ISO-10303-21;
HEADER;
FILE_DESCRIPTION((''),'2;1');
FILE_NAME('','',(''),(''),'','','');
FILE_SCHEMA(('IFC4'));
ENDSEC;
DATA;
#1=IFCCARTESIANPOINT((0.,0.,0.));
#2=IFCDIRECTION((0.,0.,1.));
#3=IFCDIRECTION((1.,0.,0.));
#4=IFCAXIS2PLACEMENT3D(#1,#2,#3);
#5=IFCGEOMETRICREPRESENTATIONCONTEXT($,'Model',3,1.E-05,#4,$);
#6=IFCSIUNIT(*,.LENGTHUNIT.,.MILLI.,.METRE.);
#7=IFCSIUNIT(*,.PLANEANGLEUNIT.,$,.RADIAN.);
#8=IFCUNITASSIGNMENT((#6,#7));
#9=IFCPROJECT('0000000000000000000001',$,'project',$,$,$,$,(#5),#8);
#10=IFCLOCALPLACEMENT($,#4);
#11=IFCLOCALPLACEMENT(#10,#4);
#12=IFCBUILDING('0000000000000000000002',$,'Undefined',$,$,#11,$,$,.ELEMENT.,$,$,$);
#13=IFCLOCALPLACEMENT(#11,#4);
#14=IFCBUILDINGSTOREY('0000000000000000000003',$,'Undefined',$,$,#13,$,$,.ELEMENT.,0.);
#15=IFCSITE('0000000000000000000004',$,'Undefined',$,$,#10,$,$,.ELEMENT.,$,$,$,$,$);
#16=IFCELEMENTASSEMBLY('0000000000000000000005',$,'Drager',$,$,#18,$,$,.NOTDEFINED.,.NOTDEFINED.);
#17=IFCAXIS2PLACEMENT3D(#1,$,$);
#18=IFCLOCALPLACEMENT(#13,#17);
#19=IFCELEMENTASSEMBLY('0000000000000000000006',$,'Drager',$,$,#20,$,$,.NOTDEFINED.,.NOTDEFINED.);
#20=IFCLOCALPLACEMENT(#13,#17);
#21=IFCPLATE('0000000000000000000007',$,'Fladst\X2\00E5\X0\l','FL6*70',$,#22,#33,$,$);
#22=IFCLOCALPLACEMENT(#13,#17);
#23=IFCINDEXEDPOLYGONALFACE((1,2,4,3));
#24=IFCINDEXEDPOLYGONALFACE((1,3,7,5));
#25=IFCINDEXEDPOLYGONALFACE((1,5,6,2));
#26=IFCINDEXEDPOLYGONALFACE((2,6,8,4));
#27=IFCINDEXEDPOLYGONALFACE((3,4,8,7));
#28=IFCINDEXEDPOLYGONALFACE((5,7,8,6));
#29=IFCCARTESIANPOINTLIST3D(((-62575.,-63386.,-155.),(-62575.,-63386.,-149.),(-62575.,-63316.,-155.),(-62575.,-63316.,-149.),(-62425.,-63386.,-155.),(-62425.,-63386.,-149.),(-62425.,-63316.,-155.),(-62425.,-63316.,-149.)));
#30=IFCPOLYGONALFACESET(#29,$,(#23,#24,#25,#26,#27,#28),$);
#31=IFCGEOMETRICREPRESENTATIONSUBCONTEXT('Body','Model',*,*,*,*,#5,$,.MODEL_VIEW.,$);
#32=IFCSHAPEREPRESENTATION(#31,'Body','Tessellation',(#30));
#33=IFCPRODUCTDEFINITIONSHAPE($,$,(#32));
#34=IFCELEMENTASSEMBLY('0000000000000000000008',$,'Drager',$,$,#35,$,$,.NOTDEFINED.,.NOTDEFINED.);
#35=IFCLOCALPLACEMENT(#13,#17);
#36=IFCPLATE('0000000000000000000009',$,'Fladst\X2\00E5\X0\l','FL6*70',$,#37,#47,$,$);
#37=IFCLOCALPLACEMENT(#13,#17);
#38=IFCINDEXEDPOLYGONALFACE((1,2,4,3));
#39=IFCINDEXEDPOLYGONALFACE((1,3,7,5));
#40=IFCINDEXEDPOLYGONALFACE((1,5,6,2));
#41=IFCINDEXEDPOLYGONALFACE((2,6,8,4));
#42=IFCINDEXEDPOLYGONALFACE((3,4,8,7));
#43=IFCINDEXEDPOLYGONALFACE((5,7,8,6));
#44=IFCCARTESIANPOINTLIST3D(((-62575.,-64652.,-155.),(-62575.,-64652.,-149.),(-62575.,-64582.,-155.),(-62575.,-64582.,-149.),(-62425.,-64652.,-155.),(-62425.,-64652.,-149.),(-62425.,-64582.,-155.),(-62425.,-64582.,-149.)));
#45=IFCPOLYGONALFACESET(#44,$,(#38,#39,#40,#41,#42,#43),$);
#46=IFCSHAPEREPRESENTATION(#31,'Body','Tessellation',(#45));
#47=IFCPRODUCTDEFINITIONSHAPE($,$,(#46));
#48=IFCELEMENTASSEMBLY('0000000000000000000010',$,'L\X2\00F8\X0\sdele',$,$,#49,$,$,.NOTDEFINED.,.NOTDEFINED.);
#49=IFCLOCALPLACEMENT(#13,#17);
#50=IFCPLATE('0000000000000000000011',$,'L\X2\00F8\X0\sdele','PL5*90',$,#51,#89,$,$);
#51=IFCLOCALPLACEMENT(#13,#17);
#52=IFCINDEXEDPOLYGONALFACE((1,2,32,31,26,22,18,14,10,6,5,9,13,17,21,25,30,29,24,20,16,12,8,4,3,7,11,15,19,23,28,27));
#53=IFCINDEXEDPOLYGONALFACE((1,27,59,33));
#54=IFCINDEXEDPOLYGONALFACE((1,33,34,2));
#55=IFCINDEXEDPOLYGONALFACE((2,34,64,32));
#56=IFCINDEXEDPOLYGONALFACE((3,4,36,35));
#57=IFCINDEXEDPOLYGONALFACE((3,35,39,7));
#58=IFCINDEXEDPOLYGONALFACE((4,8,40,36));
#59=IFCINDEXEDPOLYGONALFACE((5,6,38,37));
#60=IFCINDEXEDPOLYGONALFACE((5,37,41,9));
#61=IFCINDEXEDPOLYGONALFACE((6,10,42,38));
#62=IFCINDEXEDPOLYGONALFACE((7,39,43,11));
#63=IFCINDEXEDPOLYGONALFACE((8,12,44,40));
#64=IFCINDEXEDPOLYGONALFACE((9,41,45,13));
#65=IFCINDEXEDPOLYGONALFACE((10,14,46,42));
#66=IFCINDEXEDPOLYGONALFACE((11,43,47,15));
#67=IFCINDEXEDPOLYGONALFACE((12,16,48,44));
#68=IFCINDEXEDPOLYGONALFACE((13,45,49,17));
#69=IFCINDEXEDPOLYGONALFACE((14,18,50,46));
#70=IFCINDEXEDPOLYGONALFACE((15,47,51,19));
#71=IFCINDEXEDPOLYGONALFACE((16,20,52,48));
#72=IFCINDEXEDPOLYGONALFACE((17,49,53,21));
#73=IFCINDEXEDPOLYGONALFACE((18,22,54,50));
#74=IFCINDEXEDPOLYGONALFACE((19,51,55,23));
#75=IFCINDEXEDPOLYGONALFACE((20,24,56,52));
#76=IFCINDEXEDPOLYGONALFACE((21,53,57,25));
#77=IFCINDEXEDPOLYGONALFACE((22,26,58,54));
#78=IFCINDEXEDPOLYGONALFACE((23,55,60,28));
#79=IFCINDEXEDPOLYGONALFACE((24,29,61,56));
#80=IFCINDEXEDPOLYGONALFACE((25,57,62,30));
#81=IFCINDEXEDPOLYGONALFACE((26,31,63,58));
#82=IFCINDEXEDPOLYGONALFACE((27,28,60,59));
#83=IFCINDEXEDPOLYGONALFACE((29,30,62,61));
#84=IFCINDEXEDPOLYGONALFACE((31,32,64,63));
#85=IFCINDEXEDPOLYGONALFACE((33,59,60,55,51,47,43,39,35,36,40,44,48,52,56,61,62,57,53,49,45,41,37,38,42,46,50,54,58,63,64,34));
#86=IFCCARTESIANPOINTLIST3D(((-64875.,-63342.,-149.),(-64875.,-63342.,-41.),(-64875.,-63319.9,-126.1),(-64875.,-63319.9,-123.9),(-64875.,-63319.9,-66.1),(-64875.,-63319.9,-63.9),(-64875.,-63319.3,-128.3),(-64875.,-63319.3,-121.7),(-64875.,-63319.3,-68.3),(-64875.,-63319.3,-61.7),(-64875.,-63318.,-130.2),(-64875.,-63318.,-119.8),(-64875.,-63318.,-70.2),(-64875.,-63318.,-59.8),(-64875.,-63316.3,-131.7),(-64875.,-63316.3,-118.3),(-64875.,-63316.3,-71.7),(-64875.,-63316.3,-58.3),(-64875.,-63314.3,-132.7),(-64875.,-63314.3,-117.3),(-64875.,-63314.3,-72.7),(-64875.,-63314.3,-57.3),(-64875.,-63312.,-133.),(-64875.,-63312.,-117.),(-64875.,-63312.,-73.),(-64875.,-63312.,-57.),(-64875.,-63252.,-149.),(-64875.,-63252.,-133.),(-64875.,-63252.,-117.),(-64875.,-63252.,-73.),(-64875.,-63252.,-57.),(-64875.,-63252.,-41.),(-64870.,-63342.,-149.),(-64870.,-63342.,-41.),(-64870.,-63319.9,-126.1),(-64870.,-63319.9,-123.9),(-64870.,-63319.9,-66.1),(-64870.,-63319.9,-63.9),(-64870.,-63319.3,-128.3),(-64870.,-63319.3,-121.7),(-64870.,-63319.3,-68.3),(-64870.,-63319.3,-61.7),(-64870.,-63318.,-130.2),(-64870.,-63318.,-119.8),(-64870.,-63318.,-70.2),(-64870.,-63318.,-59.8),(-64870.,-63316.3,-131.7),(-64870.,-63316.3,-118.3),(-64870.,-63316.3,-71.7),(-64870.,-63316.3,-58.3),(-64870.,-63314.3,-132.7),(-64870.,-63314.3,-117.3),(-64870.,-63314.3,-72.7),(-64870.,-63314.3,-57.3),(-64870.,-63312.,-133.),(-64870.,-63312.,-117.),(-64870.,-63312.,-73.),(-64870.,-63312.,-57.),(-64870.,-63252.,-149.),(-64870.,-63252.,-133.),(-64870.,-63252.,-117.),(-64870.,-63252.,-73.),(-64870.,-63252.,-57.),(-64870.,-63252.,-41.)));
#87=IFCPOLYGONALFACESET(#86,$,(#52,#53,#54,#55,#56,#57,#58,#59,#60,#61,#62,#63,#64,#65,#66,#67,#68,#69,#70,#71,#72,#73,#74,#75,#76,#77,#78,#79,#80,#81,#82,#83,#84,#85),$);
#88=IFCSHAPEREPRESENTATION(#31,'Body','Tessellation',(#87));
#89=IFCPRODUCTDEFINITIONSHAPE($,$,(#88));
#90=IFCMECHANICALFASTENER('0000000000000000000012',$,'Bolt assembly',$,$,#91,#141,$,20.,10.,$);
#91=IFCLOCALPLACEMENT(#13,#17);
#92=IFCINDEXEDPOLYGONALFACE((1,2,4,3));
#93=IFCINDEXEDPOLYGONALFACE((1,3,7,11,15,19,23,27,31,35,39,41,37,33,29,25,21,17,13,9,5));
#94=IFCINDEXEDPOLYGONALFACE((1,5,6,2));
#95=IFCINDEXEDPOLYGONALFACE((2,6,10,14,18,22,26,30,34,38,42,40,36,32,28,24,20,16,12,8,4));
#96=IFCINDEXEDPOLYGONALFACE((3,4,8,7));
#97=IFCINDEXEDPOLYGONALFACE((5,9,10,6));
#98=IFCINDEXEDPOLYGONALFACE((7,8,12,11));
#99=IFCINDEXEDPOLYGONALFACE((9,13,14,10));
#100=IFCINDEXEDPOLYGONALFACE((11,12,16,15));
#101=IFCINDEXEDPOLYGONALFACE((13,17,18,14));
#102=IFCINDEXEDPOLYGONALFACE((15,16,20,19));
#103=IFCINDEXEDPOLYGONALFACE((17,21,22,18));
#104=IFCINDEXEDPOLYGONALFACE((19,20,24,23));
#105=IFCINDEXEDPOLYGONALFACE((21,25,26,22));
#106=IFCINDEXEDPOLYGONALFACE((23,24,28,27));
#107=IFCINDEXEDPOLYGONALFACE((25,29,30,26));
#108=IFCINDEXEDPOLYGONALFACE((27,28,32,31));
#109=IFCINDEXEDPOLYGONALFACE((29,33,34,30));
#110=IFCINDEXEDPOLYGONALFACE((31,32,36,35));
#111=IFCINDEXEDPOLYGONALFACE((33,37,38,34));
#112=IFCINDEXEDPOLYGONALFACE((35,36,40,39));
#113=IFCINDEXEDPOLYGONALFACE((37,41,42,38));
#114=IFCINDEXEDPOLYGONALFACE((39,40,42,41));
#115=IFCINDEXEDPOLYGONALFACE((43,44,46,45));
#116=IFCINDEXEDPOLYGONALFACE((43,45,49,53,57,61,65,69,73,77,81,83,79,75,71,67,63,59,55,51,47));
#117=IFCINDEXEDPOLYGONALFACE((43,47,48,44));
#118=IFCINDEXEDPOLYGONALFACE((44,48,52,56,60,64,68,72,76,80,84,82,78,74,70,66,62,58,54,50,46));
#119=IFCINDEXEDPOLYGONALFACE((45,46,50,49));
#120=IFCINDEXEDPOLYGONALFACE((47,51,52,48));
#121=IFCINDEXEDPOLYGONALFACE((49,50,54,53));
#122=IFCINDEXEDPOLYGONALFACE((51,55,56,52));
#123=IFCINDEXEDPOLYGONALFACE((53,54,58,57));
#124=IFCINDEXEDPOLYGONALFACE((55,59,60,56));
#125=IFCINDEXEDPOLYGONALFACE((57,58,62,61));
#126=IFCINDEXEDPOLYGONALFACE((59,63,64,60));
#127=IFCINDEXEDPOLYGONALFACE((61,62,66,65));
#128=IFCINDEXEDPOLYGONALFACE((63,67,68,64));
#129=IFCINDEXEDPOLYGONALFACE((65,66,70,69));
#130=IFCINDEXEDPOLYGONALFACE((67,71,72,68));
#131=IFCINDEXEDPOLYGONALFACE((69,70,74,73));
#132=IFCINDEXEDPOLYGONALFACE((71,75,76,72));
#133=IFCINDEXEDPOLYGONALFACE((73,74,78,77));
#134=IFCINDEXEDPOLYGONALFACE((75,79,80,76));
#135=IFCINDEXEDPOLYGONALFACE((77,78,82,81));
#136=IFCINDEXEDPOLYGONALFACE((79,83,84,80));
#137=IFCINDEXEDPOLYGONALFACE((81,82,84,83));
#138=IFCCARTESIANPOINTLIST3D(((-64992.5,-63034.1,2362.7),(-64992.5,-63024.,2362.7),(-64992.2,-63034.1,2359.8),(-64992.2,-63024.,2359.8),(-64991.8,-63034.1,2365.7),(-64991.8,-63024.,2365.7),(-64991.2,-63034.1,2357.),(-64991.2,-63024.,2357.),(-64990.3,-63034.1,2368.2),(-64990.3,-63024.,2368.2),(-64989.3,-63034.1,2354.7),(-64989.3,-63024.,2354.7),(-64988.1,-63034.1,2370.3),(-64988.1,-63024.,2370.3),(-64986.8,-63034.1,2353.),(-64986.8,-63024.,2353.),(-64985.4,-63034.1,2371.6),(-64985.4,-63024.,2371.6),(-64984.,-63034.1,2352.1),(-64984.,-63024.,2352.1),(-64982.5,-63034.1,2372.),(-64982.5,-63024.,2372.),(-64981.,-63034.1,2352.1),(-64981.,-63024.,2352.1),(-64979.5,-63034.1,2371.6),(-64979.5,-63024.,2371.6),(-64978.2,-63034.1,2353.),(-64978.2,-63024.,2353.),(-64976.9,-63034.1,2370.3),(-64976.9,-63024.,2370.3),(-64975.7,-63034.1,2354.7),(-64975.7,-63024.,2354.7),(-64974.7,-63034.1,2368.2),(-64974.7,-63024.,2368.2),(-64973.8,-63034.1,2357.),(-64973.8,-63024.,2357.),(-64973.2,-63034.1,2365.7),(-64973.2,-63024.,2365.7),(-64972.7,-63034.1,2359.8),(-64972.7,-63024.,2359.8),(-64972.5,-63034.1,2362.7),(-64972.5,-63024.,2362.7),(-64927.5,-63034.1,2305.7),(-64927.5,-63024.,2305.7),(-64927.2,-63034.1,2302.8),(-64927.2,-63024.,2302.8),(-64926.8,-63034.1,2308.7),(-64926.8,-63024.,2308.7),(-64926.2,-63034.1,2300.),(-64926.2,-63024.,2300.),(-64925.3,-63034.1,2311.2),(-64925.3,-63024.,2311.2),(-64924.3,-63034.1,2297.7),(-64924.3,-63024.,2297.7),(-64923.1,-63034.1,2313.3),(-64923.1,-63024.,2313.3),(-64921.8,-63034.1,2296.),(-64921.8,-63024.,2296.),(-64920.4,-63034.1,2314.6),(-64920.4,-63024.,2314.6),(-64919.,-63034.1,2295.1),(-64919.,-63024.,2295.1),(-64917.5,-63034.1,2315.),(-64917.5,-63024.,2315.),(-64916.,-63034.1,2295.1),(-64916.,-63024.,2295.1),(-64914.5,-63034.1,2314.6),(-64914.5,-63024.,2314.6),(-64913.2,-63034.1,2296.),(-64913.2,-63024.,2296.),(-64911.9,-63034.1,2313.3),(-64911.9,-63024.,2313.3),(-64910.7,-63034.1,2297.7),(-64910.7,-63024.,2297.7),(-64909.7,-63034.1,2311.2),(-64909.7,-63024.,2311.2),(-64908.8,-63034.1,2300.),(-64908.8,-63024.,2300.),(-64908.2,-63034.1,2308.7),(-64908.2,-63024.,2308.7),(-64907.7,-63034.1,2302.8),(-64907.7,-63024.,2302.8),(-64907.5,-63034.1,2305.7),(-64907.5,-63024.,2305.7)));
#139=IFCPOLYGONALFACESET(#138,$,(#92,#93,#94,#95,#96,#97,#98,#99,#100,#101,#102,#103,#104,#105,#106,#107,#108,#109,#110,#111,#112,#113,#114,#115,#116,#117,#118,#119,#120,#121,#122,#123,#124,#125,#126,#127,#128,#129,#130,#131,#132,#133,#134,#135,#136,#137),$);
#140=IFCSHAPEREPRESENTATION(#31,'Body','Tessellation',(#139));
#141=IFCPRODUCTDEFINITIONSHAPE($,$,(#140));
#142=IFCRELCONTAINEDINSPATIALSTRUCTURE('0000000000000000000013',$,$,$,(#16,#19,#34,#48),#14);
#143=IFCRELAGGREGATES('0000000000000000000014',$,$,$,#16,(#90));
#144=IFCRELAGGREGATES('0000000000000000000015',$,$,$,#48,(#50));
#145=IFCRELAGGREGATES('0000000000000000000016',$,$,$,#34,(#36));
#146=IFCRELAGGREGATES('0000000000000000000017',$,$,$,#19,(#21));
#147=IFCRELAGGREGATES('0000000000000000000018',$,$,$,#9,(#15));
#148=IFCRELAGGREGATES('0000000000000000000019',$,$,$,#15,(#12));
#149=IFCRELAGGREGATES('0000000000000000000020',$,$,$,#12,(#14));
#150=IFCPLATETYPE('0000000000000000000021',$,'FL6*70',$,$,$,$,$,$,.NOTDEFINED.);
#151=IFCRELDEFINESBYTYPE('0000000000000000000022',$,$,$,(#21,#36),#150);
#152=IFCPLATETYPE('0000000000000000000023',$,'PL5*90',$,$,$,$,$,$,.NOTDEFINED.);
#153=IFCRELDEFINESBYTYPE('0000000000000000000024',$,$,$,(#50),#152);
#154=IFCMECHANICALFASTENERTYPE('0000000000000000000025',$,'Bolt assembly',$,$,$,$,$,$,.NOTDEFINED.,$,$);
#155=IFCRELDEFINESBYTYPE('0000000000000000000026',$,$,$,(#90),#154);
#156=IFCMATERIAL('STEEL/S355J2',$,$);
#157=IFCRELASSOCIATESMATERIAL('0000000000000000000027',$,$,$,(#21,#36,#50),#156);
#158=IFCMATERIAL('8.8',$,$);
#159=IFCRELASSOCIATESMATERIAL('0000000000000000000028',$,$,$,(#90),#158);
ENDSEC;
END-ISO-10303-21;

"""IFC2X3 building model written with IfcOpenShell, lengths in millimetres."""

from ifc_helpers import new_model, si_unit, frame, frame_2d, origin_with_axes, origin_2d_with_axis, place, context, subcontext, project, spatial, polyline, circle_curve, parameter, trimmed, segment, composite_curve, circle, outline, extrude, boolean, source, transform, mapped, material, type_object, element, aggregate, save


model = new_model("IFC2X3")

# Units and contexts
model_context = context("Model", 3, precision=1e-05, world=origin_with_axes())
body_context = subcontext(model_context, "Body", "Model", "MODEL_VIEW")
ifc_project = project(units=[si_unit("LENGTHUNIT", "METRE", prefix="MILLI"), si_unit("PLANEANGLEUNIT", "RADIAN")], contexts=[model_context])

# Site, building, storey
site_placement = place(None, origin_with_axes())
site = spatial("IfcSite", under=ifc_project, at=site_placement, Name="Undefined", CompositionType="ELEMENT")
building_placement = place(site_placement, origin_with_axes())
building = spatial("IfcBuilding", under=site, at=building_placement, Name="Undefined", CompositionType="ELEMENT")
storey_placement = place(building_placement, origin_with_axes())
storey = spatial("IfcBuildingStorey", under=building, at=storey_placement, Name="Undefined", CompositionType="ELEMENT", Elevation=0.0)

# Element assembly
assembly_1_placement = place(storey_placement, origin_with_axes())
assembly_1 = element("IfcElementAssembly", 1, at=assembly_1_placement, inside=storey, Name="Drager", AssemblyPlace="NOTDEFINED", PredefinedType="NOTDEFINED")

# Shared definitions
ifc_material_1 = material(Name="STEEL/S355J2")

# Element assembly
assembly_2_placement = place(storey_placement, origin_with_axes())
assembly_2 = element("IfcElementAssembly", 2, at=assembly_2_placement, inside=storey, Name="Drager", AssemblyPlace="NOTDEFINED", PredefinedType="NOTDEFINED")

# Plate
plate_type_1 = type_object("IfcPlateType", Name="FL6*70", PredefinedType="NOTDEFINED")
plate_1_placement = place(assembly_2_placement, frame((-62575.0, -63351.0, -152.0), z_axis=(0.0, 0.0, 1.0), x_axis=(1.0, 0.0, 0.0)))
plate_1 = element("IfcPlate", 3, at=plate_1_placement, type_object=plate_type_1, material=ifc_material_1, Name="Fladstål", Description="FL6*70", context=body_context, shape_type="SweptSolid", body=[
    extrude(outline(polyline([(0.0, -35.0), (0.0, 35.0), (150.0, 35.0), (150.0, -35.0), (0.0, -35.0)])), frame((0.0, 0.0, -3.0), z_axis=(0.0, 0.0, 1.0), x_axis=(1.0, 0.0, 0.0)), (0.0, 0.0, 1.0), 6.0),
])

# Element assemblies, plates
assembly_3_placement = place(storey_placement, origin_with_axes())
assembly_3 = element("IfcElementAssembly", 4, at=assembly_3_placement, inside=storey, Name="Drager", AssemblyPlace="NOTDEFINED", PredefinedType="NOTDEFINED")
plate_2_placement = place(assembly_3_placement, frame((-62575.0, -64617.0, -152.0), z_axis=(0.0, 0.0, 1.0), x_axis=(1.0, 0.0, 0.0)))
plate_2 = element("IfcPlate", 5, at=plate_2_placement, type_object=plate_type_1, material=ifc_material_1, Name="Fladstål", Description="FL6*70", context=body_context, shape_type="SweptSolid", body=[
    extrude(outline(polyline([(0.0, -35.0), (0.0, 35.0), (150.0, 35.0), (150.0, -35.0), (0.0, -35.0)])), frame((0.0, 0.0, -3.0), z_axis=(0.0, 0.0, 1.0), x_axis=(1.0, 0.0, 0.0)), (0.0, 0.0, 1.0), 6.0),
])
assembly_4_placement = place(storey_placement, origin_with_axes())
assembly_4 = element("IfcElementAssembly", 6, at=assembly_4_placement, inside=storey, Name="Løsdele", AssemblyPlace="NOTDEFINED", PredefinedType="NOTDEFINED")
plate_type_2 = type_object("IfcPlateType", Name="PL5*90", PredefinedType="NOTDEFINED")
plate_3_placement = place(assembly_4_placement, frame((-64872.5, -63297.0, -41.0), z_axis=(1.0, 0.0, 0.0), x_axis=(0.0, 0.0, -1.0)))
plate_3 = element("IfcPlate", 7, at=plate_3_placement, type_object=plate_type_2, material=ifc_material_1, Name="Løsdele", Description="PL5*90", context=body_context, shape_type="CSG", body=[
    boolean("DIFFERENCE", boolean("DIFFERENCE", extrude(outline(polyline([(0.0, -45.0), (0.0, 45.0), (108.0, 45.0), (108.0, -45.0), (0.0, -45.0)])), frame((0.0, 0.0, -2.5), z_axis=(0.0, 0.0, 1.0), x_axis=(1.0, 0.0, 0.0)), (0.0, 0.0, 1.0), 5.0), extrude(outline(composite_curve([segment(polyline([(0.0, 0.0), (60.0, 0.0), (60.0, 16.0), (0.0, 16.0)]), True, "CONTINUOUS"), segment(trimmed(circle_curve(frame_2d((0.0, 8.0), x_axis=(0.0, 1.0)), 8.0), [parameter(0.0)], [parameter(1.570796)], True, "PARAMETER"), True, "CONTINUOUS"), segment(polyline([(-8.0, 8.0), (-8.0, 8.0)]), True, "CONTINUOUS"), segment(trimmed(circle_curve(frame_2d((0.0, 8.0), x_axis=(-1.0, 0.0)), 8.0), [parameter(0.0)], [parameter(1.570796)], True, "PARAMETER"), True, "CONTINUOUS"), segment(polyline([(0.0, 0.0), (0.0, 0.0)]), True, "CONTINUOUS")], self_intersect=True)), frame((92.0, -15.0, -2.5), z_axis=(0.0, 0.0, 1.0), x_axis=(0.0, 1.0, 0.0)), (0.0, 0.0, 1.0), 5.0)), extrude(outline(composite_curve([segment(polyline([(0.0, 0.0), (60.0, 0.0), (60.0, 16.0), (0.0, 16.0)]), True, "CONTINUOUS"), segment(trimmed(circle_curve(frame_2d((0.0, 8.0), x_axis=(0.0, 1.0)), 8.0), [parameter(0.0)], [parameter(1.570796)], True, "PARAMETER"), True, "CONTINUOUS"), segment(polyline([(-8.0, 8.0), (-8.0, 8.0)]), True, "CONTINUOUS"), segment(trimmed(circle_curve(frame_2d((0.0, 8.0), x_axis=(-1.0, 0.0)), 8.0), [parameter(0.0)], [parameter(1.570796)], True, "PARAMETER"), True, "CONTINUOUS"), segment(polyline([(0.0, 0.0), (0.0, 0.0)]), True, "CONTINUOUS")], self_intersect=True)), frame((32.0, -15.0, -2.5), z_axis=(0.0, 0.0, 1.0), x_axis=(0.0, 1.0, 0.0)), (0.0, 0.0, 1.0), 5.0)),
])

# Mechanical fastener
ifc_material_2 = material(Name="8.8")
mechanical_fastener_type = type_object("IfcMechanicalFastenerType", Name="Bolt assembly")
shared_shape_1 = source(origin_with_axes(), body_context, "Body", "SweptSolid", [
    extrude(circle(Radius=10.0, at=origin_2d_with_axis()), frame((0.0, 0.0, 0.0), z_axis=(0.0, 1.0, 0.0), x_axis=(1.0, 0.0, 0.0)), (0.0, 0.0, 1.0), 10.1),
])
mechanical_fastener_1_placement = place(assembly_1_placement, frame((-64950.0, -63024.0, 2305.0), z_axis=(1.0, 0.0, 0.0), x_axis=(0.0, 0.0, 1.0)))
mechanical_fastener_1 = element("IfcMechanicalFastener", 8, at=mechanical_fastener_1_placement, type_object=mechanical_fastener_type, material=ifc_material_2, Name="Bolt assembly", NominalDiameter=20.0, NominalLength=10.0, context=body_context, shape_type="MappedRepresentation", body=[
    mapped(shared_shape_1, transform((57.0, 0.0, -32.5))),
    mapped(shared_shape_1, transform((0.0, 0.0, 32.5))),
])
aggregate(assembly_1, [mechanical_fastener_1])
aggregate(assembly_4, [plate_3])

aggregate(assembly_3, [plate_2])
aggregate(assembly_2, [plate_1])

save(model, "model.ifc")
